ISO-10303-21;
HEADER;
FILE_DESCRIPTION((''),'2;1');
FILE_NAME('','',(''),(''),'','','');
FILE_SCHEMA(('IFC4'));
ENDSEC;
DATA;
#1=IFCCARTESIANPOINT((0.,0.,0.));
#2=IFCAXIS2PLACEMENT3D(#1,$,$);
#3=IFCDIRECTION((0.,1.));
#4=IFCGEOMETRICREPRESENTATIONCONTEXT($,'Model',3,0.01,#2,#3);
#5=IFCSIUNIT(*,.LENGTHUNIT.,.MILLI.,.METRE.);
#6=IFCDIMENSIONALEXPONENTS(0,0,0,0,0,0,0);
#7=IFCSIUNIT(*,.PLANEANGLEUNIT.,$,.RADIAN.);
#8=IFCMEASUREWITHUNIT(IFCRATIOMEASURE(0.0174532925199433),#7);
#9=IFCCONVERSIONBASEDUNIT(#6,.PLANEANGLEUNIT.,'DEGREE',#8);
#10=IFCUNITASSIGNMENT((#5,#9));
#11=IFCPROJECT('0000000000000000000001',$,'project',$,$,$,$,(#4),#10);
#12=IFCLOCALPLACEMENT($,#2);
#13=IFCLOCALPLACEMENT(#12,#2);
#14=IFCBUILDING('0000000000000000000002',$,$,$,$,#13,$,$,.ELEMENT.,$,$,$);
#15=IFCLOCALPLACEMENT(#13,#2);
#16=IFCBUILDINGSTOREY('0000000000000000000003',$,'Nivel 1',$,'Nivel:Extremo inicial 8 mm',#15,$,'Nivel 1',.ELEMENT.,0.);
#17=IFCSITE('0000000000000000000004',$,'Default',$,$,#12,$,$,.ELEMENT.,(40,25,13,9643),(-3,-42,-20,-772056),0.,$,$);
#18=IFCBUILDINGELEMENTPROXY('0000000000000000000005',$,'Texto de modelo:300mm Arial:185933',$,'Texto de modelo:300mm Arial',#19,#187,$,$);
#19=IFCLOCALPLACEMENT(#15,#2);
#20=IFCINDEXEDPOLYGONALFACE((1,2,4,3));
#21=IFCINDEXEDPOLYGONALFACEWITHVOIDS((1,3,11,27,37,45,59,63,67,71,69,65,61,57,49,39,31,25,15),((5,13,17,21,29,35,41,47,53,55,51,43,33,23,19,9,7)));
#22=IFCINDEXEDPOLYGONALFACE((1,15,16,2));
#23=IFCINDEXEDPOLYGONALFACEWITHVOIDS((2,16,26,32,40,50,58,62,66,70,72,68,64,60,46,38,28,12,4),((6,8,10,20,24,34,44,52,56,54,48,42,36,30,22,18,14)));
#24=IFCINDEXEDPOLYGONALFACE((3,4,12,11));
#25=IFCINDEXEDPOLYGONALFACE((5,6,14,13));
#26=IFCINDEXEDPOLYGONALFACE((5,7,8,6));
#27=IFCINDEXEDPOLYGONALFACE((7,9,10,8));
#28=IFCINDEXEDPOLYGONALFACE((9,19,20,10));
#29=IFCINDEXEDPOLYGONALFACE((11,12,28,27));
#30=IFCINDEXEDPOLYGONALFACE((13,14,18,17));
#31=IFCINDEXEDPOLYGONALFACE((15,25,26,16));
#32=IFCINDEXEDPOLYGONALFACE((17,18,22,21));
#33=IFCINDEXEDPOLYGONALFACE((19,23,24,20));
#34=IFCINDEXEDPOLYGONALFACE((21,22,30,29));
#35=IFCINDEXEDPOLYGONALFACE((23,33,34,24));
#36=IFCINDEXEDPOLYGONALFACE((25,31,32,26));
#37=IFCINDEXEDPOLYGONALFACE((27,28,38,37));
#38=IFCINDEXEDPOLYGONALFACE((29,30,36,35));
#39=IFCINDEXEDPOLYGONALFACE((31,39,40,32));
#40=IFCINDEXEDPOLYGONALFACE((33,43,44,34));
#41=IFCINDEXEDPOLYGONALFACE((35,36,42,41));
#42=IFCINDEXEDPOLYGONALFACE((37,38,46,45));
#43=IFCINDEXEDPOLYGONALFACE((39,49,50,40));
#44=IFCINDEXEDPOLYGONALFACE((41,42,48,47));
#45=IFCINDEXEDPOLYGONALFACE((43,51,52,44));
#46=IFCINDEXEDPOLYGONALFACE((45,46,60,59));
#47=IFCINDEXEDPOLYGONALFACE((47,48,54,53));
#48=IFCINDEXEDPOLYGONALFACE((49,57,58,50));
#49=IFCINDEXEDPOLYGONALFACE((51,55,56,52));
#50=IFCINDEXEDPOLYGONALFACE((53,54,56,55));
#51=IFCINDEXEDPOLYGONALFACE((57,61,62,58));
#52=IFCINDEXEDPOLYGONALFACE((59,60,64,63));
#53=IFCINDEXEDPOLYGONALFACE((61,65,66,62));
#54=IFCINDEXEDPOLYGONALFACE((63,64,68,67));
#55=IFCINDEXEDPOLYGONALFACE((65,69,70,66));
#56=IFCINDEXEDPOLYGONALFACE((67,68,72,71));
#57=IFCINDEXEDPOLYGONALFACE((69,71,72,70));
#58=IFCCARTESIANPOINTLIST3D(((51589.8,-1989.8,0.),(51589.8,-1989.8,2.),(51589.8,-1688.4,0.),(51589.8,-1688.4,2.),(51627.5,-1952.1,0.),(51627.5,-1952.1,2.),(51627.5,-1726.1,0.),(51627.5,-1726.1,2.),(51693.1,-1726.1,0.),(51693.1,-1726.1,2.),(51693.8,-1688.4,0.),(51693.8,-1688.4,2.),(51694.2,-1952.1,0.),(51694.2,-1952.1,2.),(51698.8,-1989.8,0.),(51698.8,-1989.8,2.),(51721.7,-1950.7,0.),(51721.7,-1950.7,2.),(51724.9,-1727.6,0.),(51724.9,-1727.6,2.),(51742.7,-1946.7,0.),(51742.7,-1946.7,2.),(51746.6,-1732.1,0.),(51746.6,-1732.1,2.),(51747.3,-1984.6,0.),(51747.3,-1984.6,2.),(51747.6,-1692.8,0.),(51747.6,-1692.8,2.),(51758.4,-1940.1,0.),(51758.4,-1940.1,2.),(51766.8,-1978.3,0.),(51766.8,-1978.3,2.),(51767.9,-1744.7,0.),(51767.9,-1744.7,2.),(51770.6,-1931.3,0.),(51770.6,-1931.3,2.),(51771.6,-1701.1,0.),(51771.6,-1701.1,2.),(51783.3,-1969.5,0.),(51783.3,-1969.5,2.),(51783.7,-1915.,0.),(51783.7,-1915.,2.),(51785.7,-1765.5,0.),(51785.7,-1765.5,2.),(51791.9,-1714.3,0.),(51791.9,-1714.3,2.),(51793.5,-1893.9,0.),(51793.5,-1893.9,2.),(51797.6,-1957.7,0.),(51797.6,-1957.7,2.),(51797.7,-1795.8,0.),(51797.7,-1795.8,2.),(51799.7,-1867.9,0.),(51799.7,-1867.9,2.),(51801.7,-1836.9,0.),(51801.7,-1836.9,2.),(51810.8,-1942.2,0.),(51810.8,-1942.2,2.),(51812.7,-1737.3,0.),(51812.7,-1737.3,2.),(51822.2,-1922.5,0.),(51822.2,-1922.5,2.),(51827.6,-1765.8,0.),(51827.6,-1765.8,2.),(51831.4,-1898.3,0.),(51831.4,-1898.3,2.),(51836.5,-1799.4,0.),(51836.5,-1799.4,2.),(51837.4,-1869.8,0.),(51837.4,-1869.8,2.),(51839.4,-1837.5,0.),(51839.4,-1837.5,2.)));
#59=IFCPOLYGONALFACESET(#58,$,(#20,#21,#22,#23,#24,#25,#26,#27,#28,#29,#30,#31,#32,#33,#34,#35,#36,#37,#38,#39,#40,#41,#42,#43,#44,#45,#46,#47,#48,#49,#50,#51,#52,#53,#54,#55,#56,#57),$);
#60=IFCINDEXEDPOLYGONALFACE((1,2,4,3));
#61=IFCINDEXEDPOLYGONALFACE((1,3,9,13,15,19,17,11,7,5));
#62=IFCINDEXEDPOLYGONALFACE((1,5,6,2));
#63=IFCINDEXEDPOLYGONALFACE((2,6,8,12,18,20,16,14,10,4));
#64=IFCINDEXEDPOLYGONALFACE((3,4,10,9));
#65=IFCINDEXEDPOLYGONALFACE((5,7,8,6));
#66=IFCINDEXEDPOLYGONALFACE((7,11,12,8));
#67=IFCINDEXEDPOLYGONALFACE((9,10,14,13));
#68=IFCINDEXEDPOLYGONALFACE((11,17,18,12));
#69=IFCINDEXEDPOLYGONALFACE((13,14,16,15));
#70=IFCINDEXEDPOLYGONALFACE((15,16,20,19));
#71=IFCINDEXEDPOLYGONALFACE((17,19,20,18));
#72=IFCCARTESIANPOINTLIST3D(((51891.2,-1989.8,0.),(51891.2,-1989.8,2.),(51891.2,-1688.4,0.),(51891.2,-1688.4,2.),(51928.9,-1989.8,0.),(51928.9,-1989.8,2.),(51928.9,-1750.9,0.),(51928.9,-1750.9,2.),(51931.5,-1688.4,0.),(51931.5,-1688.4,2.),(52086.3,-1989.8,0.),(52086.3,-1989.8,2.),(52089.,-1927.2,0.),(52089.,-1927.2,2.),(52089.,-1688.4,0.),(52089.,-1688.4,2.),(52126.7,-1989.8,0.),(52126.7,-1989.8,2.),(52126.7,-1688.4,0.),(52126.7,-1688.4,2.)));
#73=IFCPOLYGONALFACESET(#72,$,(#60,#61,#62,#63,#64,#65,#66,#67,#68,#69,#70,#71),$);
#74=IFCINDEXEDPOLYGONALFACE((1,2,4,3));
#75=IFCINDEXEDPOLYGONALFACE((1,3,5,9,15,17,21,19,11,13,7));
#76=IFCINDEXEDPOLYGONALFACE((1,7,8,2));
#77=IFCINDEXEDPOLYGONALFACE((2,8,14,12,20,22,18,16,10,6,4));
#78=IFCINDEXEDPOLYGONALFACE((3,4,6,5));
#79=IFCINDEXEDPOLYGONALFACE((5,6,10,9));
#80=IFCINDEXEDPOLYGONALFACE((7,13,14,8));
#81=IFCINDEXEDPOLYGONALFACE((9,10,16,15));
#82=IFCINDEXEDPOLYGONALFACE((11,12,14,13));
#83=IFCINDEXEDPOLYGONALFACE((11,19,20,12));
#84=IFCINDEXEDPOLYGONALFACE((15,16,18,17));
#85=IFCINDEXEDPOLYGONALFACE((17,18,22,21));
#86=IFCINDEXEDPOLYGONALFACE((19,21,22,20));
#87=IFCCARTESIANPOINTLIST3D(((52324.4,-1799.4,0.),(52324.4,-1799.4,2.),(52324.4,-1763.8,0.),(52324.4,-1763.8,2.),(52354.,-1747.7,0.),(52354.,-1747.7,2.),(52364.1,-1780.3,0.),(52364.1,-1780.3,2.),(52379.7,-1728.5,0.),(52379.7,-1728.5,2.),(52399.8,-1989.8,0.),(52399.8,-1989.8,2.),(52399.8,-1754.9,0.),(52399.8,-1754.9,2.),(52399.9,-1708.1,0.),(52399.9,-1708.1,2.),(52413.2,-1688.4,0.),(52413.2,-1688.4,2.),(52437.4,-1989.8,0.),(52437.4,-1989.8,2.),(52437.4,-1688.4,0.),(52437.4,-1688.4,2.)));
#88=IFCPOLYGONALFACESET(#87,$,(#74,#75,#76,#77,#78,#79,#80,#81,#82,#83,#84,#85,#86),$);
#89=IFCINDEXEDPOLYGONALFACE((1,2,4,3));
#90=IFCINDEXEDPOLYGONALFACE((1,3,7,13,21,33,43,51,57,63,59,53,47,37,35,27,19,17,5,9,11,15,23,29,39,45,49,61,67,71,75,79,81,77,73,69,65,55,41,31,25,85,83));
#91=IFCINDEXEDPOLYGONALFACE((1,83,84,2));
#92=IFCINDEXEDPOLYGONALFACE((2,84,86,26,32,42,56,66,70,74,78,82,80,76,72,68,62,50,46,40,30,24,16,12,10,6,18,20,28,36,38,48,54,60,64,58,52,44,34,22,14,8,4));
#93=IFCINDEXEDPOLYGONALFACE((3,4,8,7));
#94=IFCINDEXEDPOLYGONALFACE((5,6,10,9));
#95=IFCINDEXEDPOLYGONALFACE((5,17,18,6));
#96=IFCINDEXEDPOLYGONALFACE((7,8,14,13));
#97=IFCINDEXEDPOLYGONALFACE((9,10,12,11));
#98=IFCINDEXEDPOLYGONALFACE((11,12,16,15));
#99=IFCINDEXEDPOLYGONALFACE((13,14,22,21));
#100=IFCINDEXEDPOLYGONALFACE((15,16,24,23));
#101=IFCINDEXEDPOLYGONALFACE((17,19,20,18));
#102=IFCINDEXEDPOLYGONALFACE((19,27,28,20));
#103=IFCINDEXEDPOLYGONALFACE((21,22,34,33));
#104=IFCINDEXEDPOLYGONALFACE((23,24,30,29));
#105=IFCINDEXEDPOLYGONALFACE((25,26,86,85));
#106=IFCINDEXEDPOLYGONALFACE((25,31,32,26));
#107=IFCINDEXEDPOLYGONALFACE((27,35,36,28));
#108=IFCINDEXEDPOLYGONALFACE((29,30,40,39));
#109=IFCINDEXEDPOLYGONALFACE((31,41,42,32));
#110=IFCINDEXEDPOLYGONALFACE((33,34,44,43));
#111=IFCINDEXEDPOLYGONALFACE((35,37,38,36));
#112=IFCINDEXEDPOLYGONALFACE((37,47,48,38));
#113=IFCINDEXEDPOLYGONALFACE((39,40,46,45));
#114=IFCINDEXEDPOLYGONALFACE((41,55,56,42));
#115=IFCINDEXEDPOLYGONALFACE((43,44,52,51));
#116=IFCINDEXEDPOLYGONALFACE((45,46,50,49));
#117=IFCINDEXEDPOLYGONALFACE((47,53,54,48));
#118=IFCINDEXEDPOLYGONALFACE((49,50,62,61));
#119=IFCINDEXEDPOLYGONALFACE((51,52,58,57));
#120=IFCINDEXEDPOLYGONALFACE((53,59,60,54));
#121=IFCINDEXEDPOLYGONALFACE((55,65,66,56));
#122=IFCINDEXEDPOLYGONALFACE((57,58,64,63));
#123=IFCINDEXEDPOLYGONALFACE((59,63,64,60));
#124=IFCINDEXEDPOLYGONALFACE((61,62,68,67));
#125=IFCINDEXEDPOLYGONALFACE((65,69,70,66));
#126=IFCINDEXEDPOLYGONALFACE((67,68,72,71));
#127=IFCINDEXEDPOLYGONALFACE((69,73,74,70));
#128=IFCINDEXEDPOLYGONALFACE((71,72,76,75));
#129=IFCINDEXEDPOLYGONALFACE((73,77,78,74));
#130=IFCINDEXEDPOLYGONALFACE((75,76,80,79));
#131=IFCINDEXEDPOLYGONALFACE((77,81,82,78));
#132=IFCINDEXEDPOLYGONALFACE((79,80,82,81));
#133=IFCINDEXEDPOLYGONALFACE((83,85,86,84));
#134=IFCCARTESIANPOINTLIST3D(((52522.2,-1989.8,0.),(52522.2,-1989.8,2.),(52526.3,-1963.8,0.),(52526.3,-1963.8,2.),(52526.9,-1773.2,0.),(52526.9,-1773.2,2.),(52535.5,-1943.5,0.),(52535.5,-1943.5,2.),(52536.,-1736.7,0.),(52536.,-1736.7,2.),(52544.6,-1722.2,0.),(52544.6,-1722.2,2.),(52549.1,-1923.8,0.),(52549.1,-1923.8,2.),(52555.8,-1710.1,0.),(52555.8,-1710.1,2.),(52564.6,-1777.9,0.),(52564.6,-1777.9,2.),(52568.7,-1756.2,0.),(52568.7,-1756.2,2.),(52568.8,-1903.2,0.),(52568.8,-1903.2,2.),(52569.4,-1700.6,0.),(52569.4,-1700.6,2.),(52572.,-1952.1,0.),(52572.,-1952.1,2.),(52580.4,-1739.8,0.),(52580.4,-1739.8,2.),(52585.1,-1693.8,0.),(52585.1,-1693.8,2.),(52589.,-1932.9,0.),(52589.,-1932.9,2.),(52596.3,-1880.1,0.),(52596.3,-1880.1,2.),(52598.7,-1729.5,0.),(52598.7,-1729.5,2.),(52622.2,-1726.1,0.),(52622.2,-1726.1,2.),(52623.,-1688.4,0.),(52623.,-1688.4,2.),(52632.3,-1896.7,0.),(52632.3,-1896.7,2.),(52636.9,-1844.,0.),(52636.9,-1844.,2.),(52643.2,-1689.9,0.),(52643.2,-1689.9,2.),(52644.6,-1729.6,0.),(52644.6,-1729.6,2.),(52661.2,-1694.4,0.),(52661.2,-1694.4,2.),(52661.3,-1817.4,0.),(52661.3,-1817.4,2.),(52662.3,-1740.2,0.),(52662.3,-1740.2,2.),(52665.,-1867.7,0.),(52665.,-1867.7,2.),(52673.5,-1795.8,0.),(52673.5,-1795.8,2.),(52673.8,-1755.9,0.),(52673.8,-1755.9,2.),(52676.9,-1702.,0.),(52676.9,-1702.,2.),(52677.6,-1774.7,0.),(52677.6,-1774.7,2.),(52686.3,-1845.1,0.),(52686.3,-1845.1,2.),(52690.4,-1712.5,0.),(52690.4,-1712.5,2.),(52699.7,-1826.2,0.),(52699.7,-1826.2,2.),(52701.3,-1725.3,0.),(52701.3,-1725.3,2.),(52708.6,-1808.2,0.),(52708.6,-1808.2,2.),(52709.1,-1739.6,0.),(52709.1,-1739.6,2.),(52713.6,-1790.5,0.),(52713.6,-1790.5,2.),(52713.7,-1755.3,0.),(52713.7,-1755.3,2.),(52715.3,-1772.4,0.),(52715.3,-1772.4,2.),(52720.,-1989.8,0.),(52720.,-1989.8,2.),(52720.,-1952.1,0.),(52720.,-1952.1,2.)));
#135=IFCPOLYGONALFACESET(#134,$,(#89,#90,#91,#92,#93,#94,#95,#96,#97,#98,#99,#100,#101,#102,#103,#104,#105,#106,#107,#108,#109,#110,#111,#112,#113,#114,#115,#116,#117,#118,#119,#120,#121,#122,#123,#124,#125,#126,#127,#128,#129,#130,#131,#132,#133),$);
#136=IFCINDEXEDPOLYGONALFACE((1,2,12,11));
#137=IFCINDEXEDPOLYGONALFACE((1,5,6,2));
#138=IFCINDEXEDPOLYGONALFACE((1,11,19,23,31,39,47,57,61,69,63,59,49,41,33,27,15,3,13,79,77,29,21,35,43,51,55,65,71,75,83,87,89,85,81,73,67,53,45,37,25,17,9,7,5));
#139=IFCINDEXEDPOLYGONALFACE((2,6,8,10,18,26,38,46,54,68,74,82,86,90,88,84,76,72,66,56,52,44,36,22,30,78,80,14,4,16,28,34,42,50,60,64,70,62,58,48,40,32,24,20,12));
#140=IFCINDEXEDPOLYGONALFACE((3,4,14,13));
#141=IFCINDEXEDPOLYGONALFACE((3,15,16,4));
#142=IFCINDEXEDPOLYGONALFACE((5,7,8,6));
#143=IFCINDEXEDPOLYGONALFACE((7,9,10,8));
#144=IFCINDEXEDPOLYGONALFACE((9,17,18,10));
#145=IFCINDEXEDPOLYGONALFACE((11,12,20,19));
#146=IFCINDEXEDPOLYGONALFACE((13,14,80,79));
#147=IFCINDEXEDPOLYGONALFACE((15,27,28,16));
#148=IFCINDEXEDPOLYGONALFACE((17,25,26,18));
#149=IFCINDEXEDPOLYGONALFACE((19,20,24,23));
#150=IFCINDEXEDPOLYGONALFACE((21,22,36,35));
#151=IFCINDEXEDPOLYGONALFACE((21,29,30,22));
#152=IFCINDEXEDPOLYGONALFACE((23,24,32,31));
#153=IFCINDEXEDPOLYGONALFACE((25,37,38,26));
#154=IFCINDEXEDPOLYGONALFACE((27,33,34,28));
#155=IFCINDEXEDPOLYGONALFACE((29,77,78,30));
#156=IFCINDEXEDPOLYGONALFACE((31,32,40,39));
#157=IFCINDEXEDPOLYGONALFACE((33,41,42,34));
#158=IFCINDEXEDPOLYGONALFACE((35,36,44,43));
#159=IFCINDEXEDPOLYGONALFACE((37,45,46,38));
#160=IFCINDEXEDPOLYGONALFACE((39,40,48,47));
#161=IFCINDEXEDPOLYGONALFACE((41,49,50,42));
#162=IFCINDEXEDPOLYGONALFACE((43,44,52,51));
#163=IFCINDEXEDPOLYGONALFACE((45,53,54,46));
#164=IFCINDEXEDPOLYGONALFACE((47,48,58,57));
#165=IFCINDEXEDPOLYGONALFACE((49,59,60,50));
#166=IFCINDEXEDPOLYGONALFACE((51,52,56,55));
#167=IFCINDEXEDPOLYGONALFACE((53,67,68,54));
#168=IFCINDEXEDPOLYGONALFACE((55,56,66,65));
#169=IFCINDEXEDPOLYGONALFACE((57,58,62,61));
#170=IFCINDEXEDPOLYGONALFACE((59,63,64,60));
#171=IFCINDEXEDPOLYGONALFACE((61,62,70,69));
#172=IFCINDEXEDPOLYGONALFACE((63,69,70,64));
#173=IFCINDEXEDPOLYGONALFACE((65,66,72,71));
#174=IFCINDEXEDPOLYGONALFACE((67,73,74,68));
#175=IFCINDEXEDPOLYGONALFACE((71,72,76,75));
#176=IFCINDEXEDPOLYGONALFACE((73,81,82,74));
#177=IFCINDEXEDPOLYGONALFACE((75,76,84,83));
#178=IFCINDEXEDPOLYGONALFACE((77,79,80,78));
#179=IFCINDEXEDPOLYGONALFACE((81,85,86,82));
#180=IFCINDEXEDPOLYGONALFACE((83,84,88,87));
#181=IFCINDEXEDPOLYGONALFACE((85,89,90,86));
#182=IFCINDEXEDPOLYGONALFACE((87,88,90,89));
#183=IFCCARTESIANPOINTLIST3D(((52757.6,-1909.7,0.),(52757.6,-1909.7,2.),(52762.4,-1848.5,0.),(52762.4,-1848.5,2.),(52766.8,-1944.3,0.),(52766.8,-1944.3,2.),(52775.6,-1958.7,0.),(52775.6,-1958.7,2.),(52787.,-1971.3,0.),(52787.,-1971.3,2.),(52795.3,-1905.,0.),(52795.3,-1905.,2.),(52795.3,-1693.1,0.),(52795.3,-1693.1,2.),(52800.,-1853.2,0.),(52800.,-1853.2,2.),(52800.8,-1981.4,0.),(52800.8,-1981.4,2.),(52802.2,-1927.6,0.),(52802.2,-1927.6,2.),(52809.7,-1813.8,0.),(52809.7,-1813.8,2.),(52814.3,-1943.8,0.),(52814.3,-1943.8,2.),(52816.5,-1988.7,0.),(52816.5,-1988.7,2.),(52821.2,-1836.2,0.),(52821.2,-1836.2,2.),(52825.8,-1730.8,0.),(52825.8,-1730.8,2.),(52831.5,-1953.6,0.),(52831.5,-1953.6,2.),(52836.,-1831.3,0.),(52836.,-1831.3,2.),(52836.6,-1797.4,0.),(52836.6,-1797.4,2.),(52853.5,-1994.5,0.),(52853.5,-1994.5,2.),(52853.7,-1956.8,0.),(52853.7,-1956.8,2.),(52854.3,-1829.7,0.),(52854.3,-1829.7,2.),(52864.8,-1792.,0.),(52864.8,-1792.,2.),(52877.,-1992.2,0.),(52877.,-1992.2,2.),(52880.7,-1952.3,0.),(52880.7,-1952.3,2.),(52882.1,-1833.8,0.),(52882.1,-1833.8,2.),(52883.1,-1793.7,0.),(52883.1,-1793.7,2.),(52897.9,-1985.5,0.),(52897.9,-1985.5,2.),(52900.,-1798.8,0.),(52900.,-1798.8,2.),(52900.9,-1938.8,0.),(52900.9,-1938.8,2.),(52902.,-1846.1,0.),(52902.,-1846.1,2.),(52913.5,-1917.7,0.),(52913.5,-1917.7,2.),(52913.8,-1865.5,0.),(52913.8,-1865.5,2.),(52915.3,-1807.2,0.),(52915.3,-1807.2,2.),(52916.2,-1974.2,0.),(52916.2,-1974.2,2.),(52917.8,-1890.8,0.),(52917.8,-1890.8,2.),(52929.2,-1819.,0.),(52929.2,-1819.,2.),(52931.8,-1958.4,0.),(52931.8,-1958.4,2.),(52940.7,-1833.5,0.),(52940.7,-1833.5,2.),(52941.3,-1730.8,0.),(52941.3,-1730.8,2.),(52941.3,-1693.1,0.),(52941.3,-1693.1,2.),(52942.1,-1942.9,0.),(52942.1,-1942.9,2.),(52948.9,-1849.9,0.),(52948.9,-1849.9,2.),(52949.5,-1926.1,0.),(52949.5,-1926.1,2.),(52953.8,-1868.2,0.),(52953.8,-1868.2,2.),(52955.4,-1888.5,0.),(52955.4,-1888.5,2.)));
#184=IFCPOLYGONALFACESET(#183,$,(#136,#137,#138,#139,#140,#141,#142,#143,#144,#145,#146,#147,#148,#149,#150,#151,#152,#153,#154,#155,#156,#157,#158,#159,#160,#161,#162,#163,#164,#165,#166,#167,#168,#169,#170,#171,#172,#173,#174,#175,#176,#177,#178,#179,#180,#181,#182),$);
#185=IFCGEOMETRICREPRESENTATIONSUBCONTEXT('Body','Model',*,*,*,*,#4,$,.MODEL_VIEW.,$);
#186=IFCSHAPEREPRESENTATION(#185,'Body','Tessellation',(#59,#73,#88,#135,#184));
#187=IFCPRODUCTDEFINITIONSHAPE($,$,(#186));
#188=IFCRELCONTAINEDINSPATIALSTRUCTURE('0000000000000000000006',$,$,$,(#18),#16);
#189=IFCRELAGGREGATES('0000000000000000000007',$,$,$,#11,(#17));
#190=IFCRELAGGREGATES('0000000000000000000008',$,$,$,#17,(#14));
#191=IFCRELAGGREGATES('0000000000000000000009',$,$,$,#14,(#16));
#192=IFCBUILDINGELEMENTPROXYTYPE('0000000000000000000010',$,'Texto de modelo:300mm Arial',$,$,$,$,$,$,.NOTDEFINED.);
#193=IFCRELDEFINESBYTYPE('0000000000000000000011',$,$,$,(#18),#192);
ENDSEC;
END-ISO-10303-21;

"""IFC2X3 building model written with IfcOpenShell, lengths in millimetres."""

from ifc_helpers import new_model, entity, si_unit, converted_unit, direction, frame, origin, place, context, subcontext, project, spatial, polyline, outline, extrude, type_object, element, save


model = new_model("IFC2X3")

# Units and contexts
model_context = context("Model", 3, precision=0.01, world=origin(), true_north=direction((0.0, 1.0)))
body_context = subcontext(model_context, "Body", "Model", "MODEL_VIEW")
ifc_project = project(units=[si_unit("LENGTHUNIT", "METRE", prefix="MILLI"), converted_unit("PLANEANGLEUNIT", "DEGREE", entity("IfcRatioMeasure", 0.0174532925199433), si_unit("PLANEANGLEUNIT", "RADIAN"), dimensions=[0, 0, 0, 0, 0, 0, 0])], contexts=[model_context])

# Site, building, storey
site_placement = place(None, origin())
site = spatial("IfcSite", under=ifc_project, at=site_placement, Name="Default", CompositionType="ELEMENT", RefLatitude=(40, 25, 13, 9643), RefLongitude=(-3, -42, -20, -772056), RefElevation=0.0)
building_placement = place(site_placement, origin())
building = spatial("IfcBuilding", under=site, at=building_placement, CompositionType="ELEMENT")
storey_placement = place(building_placement, origin())
storey = spatial("IfcBuildingStorey", under=building, at=storey_placement, Name="Nivel 1", ObjectType="Nivel:Extremo inicial 8 mm", LongName="Nivel 1", CompositionType="ELEMENT", Elevation=0.0)

# Building element proxy
building_element_proxy_type_1 = type_object("IfcBuildingElementProxyType", Name="Texto de modelo:300mm Arial", PredefinedType="NOTDEFINED")
proxy_1_placement = place(storey_placement, frame((51589.8, -1994.5, 0.0)))
element("IfcBuildingElementProxy", 1, at=proxy_1_placement, inside=storey, type_object=building_element_proxy_type_1, Name="Texto de modelo:300mm Arial:185933", ObjectType="Texto de modelo:300mm Arial", context=body_context, shape_type="SweptSolid", body=[
    extrude(outline(polyline([(-178.4, -141.0), (-69.4, -141.0), (-21.0, -135.8), (-1.4, -129.5), (15.0, -120.7), (29.4, -108.9), (42.6, -93.4), (54.0, -73.7), (63.2, -49.5), (69.2, -21.0), (71.2, 11.3), (68.2, 49.4), (59.3, 83.0), (44.5, 111.5), (23.7, 134.5), (3.4, 147.7), (-20.6, 156.1), (-74.4, 160.4), (-178.4, 160.4), (-178.4, -141.0)]), holes=[polyline([(-140.7, -103.3), (-140.7, 122.7), (-75.1, 122.7), (-43.3, 121.2), (-21.7, 116.7), (-0.4, 104.1), (17.4, 83.3), (29.5, 53.0), (33.5, 11.9), (31.5, -19.1), (25.3, -45.1), (15.5, -66.2), (2.4, -82.5), (-9.8, -91.3), (-25.6, -97.9), (-46.5, -101.9), (-74.1, -103.3), (-140.7, -103.3)])]), frame((178.4, 145.7, 0.0)), (0.0, 0.0, 1.0), 2.0),
    extrude(outline(polyline([(-117.7, -150.7), (-80.1, -150.7), (-80.1, 88.1), (77.4, -150.7), (117.7, -150.7), (117.7, 150.7), (80.1, 150.7), (80.1, -88.1), (-77.4, 150.7), (-117.7, 150.7), (-117.7, -150.7)])), frame((419.1, 155.4, 0.0)), (0.0, 0.0, 1.0), 2.0),
    extrude(outline(polyline([(-204.4, -52.5), (97.0, -52.5), (97.0, -28.2), (77.2, -14.9), (56.9, 5.3), (37.7, 30.9), (21.6, 60.5), (-14.0, 60.5), (5.0, 20.8), (30.4, -14.9), (-204.4, -14.9), (-204.4, -52.5)])), frame((795.1, 209.1, 0.0), z_axis=(0.0, 0.0, 1.0), x_axis=(0.0, 1.0, 0.0)), (0.0, 0.0, 1.0), 2.0),
    extrude(outline(polyline([(-91.6, -150.5), (-91.6, -188.2), (106.2, -188.2), (102.1, -162.2), (92.9, -141.9), (79.3, -122.2), (59.6, -101.6), (32.1, -78.5), (-8.5, -42.4), (-32.9, -15.8), (-45.1, 5.8), (-49.2, 26.9), (-45.4, 45.8), (-33.9, 61.4), (-16.2, 72.0), (6.2, 75.5), (29.7, 72.1), (48.0, 61.8), (59.7, 45.4), (63.8, 23.7), (101.5, 28.4), (92.4, 64.9), (83.8, 79.4), (72.6, 91.5), (59.0, 101.0), (43.3, 107.8), (5.4, 113.2), (-14.8, 111.7), (-32.8, 107.2), (-48.5, 99.6), (-62.0, 89.1), (-72.9, 76.3), (-80.7, 62.0), (-85.3, 46.3), (-86.9, 29.2), (-85.2, 11.2), (-80.2, -6.5), (-71.3, -24.6), (-57.9, -43.5), (-36.6, -66.1), (-3.9, -95.1), (39.4, -131.3), (56.4, -150.5), (-91.6, -150.5)])), frame((1038.6, 192.9, 0.0), z_axis=(0.0, 0.0, -1.0), x_axis=(-1.0, 0.0, 0.0)), (0.0, 0.0, -1.0), 2.0),
    extrude(outline(polyline([(1.4, -113.1), (37.2, -113.1), (53.4, -108.4), (68.5, -100.5), (81.8, -89.8), (92.9, -76.5), (108.0, -42.2), (111.8, -18.9), (110.6, 3.0), (104.4, 23.5), (93.2, 42.7), (80.9, 56.7), (66.6, 68.1), (31.7, 83.5), (11.7, 87.1), (-7.3, 87.1), (-25.2, 83.4), (-42.2, 76.0), (-57.1, 65.7), (-69.2, 53.0), (-78.5, 38.0), (-84.8, 20.7), (-86.8, -7.9), (-77.9, -38.1), (-154.0, -1.2), (-124.3, 110.4), (-160.7, 120.1), (-198.2, -21.0), (-56.5, -92.8), (-42.3, -57.6), (-53.3, -32.8), (-54.2, -17.2), (-51.1, 0.9), (-40.0, 26.8), (-23.0, 42.8), (-1.2, 49.2), (24.3, 46.5), (49.2, 35.5), (66.3, 17.9), (74.2, -5.1), (71.6, -32.4), (62.8, -53.0), (48.9, -67.1), (30.2, -74.6), (6.6, -75.5), (1.4, -113.1)])), frame((1276.7, 115.2, 0.0), z_axis=(0.0, 0.0, 1.0), x_axis=(0.256974, -0.966418, 0.0)), (0.0, 0.0, 1.0), 2.0),
])

save(model, "model.ifc")
